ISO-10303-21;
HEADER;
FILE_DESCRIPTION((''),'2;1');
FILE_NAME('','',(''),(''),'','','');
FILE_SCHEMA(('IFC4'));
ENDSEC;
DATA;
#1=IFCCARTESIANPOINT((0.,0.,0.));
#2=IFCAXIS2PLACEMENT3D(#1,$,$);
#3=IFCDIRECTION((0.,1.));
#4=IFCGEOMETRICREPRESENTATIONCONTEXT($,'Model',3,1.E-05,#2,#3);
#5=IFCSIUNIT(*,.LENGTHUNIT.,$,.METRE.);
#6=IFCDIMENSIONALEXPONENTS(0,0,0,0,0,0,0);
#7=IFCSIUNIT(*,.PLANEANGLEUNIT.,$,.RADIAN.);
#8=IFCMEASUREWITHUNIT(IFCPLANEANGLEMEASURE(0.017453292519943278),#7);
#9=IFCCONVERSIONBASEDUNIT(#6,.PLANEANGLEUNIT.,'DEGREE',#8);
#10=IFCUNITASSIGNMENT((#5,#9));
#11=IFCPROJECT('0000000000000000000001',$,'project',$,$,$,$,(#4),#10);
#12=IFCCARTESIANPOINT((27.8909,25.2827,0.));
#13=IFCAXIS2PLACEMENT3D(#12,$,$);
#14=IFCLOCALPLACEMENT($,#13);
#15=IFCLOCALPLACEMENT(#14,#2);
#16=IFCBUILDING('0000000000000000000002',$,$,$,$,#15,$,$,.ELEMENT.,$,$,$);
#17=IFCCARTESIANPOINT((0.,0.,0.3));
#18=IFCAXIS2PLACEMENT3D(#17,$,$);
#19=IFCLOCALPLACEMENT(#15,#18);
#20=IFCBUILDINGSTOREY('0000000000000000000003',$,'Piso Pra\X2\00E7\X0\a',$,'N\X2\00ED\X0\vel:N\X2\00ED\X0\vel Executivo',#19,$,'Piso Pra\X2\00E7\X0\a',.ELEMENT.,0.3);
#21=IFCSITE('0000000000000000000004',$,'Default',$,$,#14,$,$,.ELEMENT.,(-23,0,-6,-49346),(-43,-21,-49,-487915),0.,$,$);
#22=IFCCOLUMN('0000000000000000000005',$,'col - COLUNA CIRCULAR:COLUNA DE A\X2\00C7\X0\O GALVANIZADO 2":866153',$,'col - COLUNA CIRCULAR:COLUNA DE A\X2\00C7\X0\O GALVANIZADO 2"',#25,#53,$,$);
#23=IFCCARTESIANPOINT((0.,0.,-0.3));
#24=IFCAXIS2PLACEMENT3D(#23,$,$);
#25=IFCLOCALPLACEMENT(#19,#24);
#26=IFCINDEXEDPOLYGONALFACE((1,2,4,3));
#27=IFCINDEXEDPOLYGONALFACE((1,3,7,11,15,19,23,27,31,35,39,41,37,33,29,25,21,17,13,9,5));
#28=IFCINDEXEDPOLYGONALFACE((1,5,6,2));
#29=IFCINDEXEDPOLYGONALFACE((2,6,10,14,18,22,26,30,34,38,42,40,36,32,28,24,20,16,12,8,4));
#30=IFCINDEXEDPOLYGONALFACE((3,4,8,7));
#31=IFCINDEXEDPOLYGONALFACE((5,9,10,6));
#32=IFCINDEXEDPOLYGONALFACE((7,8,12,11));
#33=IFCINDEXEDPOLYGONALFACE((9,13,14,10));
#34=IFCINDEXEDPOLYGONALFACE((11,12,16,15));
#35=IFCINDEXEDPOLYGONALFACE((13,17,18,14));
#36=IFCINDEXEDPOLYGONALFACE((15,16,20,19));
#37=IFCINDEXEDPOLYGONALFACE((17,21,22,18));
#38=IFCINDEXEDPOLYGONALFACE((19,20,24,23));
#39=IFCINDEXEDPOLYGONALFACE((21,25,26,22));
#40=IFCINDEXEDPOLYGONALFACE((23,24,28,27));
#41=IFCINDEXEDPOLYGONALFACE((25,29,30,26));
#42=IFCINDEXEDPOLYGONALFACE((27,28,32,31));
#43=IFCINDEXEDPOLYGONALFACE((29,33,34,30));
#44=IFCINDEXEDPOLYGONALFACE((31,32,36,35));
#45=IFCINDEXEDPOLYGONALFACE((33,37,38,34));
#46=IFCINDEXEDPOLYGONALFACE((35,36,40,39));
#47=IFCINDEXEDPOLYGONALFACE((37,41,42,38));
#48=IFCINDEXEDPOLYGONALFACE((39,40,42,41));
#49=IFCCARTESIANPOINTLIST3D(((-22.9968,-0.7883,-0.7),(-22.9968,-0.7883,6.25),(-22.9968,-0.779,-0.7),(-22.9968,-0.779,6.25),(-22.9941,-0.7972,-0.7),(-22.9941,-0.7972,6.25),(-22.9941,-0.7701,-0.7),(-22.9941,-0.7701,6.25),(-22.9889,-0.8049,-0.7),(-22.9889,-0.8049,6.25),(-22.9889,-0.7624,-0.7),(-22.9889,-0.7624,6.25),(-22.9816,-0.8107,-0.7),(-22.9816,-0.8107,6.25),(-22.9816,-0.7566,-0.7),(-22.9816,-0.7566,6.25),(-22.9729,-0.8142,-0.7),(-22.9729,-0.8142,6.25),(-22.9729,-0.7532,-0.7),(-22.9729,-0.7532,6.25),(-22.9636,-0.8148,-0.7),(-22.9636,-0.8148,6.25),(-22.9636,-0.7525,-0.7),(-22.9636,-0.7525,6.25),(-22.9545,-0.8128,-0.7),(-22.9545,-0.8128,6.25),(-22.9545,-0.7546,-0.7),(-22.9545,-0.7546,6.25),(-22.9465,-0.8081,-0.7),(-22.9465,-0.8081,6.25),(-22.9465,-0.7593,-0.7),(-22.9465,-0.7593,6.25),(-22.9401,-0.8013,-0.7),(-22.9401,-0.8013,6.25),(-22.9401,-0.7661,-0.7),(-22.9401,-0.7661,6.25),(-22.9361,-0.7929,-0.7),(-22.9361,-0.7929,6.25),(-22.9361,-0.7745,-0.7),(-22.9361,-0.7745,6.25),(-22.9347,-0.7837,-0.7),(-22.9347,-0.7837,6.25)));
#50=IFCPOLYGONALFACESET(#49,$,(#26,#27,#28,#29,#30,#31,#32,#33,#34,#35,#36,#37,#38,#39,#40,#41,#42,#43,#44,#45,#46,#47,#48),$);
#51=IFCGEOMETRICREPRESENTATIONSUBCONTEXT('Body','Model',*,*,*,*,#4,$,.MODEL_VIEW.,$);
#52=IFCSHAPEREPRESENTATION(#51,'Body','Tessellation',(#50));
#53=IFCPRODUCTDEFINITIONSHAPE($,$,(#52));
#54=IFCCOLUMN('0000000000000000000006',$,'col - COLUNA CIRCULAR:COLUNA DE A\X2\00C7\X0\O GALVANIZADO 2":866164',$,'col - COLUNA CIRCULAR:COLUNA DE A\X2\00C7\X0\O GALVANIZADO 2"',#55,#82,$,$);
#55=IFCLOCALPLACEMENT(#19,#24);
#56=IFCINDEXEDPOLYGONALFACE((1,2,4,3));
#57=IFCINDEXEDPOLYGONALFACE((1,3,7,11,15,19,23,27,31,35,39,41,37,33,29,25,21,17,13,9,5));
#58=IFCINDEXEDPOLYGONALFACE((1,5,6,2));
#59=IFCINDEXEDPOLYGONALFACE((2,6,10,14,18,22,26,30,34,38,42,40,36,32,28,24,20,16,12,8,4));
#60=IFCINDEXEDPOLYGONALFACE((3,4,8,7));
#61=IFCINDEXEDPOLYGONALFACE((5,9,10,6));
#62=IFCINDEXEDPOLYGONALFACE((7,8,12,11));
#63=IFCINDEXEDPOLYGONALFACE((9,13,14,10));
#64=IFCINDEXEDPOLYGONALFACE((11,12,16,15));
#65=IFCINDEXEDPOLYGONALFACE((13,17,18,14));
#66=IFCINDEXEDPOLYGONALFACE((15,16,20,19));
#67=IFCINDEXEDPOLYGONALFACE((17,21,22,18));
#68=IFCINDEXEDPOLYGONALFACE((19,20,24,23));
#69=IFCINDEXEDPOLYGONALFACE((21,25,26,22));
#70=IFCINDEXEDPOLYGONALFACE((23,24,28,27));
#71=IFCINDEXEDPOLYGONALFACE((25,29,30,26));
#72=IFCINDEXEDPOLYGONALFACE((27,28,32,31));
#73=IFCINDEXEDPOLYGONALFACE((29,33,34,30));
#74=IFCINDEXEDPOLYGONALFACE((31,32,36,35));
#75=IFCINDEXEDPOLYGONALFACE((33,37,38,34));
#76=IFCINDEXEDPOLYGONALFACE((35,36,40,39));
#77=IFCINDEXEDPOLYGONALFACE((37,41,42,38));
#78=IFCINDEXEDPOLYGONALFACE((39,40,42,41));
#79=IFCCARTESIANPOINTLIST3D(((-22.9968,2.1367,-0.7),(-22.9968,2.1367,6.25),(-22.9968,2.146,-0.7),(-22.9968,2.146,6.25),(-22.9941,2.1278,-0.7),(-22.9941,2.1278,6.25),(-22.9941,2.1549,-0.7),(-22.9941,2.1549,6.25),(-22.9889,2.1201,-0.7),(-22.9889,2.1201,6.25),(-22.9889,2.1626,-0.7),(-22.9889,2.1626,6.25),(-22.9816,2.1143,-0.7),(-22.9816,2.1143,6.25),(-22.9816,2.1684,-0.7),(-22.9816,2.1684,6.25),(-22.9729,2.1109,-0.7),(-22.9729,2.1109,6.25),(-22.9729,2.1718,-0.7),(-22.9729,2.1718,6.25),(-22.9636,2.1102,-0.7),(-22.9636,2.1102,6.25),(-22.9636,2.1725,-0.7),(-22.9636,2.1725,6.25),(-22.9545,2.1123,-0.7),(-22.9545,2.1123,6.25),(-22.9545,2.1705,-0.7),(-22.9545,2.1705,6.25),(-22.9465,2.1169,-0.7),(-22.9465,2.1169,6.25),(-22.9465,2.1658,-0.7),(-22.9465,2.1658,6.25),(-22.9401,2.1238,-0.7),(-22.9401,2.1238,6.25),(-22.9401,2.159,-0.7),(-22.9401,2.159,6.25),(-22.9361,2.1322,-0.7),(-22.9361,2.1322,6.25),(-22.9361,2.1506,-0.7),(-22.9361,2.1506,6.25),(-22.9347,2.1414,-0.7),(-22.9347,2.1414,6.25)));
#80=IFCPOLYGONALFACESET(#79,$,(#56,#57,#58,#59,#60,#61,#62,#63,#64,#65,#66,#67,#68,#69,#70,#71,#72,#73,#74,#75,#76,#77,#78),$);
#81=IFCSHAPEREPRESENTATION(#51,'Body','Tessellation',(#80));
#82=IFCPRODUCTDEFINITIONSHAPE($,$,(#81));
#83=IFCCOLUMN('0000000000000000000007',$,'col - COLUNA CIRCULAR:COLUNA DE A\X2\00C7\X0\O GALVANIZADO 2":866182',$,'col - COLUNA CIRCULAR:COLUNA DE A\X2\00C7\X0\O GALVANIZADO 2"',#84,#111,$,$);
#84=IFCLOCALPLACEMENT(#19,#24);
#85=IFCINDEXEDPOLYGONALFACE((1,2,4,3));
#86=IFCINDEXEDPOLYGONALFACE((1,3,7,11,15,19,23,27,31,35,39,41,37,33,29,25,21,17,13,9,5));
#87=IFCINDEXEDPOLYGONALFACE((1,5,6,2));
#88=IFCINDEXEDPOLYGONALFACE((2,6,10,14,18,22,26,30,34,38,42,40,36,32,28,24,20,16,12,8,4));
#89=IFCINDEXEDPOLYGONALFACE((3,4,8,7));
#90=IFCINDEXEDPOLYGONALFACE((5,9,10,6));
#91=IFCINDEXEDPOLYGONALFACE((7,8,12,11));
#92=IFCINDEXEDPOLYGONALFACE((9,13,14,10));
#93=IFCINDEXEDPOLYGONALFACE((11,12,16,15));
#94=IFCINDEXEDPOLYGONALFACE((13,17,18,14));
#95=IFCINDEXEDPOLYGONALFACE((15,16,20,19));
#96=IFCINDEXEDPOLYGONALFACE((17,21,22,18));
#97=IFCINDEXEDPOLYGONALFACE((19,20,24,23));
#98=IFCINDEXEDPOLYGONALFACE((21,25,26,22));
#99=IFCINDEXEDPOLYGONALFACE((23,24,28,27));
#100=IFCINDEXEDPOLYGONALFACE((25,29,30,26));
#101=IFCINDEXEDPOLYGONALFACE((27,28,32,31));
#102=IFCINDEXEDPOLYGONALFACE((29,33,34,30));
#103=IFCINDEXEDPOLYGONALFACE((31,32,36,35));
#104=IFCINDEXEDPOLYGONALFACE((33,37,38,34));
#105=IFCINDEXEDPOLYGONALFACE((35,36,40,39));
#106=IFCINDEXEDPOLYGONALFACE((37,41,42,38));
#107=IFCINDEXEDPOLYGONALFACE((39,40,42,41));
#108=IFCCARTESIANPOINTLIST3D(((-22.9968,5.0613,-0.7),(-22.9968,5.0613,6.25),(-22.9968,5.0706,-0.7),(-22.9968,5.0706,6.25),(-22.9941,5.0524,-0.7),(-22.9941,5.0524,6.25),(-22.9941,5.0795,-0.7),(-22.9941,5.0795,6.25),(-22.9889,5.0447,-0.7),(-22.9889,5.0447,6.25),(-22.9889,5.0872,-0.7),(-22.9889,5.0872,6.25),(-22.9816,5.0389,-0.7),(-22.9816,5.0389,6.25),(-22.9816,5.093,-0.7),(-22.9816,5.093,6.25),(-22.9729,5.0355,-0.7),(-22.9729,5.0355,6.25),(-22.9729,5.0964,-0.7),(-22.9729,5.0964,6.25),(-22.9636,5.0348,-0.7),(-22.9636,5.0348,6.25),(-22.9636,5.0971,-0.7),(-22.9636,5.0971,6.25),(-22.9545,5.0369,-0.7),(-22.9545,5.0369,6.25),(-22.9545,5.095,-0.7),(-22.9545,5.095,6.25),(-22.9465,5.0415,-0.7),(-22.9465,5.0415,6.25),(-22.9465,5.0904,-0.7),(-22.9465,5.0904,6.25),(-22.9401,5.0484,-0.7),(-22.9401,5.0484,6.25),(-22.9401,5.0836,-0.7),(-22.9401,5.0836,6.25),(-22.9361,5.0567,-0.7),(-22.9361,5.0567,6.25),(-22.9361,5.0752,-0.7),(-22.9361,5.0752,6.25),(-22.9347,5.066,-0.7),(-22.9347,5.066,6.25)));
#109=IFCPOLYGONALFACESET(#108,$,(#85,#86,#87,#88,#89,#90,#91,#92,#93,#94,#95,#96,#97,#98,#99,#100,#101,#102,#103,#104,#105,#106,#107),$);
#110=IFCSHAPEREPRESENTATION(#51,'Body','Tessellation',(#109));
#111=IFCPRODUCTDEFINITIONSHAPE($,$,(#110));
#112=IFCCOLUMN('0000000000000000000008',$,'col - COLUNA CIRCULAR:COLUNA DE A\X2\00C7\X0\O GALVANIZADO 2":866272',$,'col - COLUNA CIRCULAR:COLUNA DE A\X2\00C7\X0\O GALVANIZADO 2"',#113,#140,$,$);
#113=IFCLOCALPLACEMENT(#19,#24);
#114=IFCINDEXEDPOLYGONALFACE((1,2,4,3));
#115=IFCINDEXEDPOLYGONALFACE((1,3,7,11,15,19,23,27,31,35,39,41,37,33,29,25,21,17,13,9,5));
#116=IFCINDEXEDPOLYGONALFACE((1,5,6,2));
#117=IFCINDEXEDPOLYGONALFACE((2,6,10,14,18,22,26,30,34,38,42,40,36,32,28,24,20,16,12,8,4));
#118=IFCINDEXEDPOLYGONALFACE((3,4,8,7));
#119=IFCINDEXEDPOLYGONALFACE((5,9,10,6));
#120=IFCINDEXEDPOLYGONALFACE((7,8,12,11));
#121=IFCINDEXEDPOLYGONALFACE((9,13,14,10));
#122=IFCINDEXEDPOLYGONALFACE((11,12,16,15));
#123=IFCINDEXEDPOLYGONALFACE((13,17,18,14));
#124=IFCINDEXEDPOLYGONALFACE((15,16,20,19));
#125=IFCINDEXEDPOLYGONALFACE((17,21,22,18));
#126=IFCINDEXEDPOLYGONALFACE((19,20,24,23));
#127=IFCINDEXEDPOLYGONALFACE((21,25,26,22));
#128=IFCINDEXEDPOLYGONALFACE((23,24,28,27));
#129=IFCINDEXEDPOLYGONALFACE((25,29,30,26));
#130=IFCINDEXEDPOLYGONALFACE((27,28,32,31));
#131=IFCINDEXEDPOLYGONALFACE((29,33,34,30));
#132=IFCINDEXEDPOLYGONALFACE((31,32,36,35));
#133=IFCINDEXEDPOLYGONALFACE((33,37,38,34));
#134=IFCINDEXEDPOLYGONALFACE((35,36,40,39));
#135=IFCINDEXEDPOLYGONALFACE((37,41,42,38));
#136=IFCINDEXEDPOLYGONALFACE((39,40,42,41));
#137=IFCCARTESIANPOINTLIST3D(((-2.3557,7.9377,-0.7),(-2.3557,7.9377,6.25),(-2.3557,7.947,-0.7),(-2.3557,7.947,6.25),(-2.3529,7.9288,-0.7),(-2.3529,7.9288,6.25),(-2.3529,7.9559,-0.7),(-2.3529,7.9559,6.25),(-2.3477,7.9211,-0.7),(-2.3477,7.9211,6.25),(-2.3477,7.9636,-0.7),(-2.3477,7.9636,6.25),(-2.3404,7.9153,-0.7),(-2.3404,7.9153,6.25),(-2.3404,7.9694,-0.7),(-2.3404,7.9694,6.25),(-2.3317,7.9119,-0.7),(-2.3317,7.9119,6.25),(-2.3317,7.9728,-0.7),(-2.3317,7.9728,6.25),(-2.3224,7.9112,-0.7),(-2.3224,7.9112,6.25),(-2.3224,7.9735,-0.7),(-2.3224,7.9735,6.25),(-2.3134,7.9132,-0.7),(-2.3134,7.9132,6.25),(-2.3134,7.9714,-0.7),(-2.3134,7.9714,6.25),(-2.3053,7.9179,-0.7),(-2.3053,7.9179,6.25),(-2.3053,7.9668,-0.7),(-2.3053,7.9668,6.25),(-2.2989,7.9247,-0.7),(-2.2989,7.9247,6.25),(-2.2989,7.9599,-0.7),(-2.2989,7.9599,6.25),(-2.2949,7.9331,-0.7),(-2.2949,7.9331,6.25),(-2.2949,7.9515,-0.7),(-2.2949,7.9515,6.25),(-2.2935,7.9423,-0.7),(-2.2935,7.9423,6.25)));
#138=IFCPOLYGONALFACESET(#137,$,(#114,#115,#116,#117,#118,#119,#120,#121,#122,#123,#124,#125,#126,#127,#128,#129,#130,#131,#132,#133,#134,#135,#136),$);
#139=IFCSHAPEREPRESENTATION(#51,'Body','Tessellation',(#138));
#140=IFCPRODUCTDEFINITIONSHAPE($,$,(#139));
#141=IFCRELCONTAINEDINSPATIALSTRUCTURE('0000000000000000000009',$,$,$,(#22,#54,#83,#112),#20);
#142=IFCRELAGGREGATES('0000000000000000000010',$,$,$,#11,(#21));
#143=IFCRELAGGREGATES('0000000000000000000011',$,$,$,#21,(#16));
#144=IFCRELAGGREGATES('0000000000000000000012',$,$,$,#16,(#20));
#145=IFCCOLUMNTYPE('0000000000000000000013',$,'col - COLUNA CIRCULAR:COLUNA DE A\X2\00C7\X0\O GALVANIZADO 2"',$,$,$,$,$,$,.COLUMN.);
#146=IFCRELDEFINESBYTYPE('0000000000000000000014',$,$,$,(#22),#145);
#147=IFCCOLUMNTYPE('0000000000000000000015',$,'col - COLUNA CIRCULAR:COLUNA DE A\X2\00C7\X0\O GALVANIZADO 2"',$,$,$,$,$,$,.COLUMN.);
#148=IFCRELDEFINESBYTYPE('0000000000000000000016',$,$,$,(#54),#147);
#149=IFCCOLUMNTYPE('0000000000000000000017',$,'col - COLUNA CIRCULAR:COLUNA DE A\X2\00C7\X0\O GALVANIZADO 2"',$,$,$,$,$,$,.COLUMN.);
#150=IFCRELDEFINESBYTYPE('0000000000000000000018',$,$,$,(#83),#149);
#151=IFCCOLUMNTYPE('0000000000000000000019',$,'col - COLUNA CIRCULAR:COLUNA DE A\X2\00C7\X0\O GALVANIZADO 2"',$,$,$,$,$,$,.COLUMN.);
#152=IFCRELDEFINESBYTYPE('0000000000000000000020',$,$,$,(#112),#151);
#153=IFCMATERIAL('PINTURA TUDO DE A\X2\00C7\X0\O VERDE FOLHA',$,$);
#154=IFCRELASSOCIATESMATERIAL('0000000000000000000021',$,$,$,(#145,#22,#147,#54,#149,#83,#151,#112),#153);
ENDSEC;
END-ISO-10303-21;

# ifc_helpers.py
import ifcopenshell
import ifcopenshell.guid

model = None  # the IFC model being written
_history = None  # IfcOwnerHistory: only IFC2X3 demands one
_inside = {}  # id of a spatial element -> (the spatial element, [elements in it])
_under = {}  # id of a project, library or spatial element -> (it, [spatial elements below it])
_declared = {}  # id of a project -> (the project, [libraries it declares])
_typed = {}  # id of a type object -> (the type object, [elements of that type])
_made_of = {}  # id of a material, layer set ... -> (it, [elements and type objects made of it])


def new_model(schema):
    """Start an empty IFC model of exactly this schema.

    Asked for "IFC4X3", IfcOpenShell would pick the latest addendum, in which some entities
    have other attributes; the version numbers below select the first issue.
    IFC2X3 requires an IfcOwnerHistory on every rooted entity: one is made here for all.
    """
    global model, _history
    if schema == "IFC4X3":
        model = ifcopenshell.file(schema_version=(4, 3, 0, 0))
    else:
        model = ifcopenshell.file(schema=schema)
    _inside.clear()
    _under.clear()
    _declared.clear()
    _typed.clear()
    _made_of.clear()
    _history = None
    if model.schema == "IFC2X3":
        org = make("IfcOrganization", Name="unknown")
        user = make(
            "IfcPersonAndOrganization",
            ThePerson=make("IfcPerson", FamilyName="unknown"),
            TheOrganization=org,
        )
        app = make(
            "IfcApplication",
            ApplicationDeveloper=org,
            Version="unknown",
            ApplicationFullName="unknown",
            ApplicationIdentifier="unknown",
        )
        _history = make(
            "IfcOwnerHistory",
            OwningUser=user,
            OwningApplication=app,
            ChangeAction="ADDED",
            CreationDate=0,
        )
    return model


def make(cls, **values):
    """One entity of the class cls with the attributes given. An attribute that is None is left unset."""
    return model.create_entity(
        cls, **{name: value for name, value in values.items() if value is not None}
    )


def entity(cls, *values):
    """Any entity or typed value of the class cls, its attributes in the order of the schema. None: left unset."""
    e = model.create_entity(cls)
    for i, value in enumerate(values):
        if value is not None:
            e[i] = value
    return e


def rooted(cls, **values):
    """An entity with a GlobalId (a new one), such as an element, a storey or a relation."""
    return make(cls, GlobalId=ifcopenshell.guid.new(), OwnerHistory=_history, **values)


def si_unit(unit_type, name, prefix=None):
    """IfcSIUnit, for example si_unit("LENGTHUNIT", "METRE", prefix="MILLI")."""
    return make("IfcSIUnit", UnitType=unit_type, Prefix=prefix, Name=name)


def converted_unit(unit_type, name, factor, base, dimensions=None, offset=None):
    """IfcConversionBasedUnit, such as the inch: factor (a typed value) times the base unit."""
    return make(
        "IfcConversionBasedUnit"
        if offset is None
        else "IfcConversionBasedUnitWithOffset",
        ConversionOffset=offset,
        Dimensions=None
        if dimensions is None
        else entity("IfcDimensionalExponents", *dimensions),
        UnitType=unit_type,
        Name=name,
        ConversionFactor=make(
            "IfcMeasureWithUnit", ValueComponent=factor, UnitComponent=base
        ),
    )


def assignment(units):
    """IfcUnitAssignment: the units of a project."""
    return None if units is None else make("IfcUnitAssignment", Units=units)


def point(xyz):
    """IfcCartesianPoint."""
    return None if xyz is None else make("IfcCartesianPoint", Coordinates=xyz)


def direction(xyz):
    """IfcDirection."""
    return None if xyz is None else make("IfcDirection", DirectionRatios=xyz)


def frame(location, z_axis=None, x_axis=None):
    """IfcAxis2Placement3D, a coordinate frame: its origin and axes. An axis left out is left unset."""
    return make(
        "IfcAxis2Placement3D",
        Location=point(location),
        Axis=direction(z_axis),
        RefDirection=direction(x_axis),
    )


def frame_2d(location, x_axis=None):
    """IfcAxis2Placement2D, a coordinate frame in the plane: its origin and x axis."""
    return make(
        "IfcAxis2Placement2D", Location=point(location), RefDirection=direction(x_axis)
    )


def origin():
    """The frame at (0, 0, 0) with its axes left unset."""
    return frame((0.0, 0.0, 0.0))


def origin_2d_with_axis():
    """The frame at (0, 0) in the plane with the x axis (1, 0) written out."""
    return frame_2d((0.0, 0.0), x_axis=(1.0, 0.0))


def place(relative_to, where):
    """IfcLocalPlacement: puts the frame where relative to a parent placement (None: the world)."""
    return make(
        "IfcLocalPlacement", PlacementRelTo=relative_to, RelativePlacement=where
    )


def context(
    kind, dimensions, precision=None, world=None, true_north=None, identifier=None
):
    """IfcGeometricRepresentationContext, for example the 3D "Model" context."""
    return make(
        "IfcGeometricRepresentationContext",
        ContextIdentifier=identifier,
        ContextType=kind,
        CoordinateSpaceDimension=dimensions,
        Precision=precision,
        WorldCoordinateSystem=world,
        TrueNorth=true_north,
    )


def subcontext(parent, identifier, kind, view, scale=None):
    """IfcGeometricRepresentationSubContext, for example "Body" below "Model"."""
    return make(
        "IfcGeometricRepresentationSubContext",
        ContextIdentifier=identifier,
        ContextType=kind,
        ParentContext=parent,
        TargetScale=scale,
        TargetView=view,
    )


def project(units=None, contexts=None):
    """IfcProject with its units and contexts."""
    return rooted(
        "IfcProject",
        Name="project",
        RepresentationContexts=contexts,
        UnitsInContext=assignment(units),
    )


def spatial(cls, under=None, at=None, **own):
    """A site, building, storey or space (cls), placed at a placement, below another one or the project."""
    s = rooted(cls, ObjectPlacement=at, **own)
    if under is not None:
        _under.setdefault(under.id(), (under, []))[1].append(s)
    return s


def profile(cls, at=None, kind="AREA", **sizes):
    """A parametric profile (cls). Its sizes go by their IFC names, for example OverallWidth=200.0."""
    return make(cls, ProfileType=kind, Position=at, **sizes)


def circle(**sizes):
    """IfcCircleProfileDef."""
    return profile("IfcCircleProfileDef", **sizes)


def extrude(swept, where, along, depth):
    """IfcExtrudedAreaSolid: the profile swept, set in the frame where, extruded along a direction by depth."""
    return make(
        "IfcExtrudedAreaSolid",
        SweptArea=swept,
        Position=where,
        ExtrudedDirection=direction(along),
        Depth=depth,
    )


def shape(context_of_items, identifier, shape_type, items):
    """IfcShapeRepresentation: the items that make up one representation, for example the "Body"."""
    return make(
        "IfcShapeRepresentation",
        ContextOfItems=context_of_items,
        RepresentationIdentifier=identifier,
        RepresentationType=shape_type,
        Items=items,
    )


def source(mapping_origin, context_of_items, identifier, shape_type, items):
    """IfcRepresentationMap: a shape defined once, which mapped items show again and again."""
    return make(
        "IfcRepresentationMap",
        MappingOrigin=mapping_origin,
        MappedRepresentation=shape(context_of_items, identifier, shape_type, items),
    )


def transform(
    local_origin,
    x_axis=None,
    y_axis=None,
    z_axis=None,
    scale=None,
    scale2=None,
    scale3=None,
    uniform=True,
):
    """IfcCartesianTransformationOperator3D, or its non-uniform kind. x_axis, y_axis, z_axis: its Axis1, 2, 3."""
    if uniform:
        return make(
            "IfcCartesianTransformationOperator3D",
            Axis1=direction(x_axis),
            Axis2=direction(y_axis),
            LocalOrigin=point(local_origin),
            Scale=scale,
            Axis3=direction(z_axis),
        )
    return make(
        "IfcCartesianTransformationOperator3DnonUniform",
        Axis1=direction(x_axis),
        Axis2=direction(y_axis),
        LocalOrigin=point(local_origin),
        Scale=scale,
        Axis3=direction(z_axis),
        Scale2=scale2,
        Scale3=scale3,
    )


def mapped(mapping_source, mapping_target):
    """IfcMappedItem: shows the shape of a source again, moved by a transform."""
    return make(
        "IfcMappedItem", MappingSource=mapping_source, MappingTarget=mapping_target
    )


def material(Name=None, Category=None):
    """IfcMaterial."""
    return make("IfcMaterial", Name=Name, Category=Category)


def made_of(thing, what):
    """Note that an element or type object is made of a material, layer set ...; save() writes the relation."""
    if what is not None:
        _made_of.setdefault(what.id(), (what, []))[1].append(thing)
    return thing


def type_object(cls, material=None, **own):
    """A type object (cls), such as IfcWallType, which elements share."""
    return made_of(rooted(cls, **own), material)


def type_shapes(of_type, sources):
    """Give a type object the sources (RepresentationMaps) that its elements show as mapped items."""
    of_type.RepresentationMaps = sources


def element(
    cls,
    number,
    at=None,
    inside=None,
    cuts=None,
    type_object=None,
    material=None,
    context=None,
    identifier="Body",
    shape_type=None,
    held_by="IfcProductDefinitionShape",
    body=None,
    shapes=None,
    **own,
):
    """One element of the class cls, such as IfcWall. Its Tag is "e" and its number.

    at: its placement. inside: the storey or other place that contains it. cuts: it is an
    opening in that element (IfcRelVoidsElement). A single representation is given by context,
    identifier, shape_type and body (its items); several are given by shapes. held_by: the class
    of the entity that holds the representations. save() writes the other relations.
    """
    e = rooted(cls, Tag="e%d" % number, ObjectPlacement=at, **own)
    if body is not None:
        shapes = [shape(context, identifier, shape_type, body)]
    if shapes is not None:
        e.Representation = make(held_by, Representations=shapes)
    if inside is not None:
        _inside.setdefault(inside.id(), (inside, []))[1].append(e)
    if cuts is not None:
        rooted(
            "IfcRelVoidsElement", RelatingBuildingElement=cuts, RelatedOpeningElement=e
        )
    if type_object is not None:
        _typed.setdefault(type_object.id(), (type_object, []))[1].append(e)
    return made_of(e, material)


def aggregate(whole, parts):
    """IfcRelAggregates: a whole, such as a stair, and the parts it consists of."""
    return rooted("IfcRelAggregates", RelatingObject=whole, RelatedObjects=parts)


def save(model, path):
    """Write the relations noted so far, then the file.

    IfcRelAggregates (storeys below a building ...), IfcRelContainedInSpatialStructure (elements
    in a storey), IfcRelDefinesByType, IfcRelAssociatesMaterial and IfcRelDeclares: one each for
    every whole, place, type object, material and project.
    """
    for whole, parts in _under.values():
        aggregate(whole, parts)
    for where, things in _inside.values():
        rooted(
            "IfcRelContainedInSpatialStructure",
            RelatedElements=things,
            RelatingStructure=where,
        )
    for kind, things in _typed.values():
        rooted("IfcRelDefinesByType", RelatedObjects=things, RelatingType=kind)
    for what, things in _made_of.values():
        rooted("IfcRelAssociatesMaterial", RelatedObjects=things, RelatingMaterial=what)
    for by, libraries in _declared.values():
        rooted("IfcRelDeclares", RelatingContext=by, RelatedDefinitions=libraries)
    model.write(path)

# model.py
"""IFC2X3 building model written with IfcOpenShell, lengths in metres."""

from ifc_helpers import new_model, entity, si_unit, converted_unit, direction, frame, origin, origin_2d_with_axis, place, context, subcontext, project, spatial, circle, extrude, source, transform, mapped, material, type_object, type_shapes, element, save


model = new_model("IFC2X3")

# Units and contexts
model_context = context("Model", 3, precision=1e-05, world=origin(), true_north=direction((0.0, 1.0)))
body_context = subcontext(model_context, "Body", "Model", "MODEL_VIEW")
ifc_project = project(units=[si_unit("LENGTHUNIT", "METRE"), converted_unit("PLANEANGLEUNIT", "DEGREE", entity("IfcPlaneAngleMeasure", 0.017453292519943278), si_unit("PLANEANGLEUNIT", "RADIAN"), dimensions=[0, 0, 0, 0, 0, 0, 0])], contexts=[model_context])

# Site, building, storey
site_placement = place(None, frame((27.8909, 25.2827, 0.0)))
site = spatial("IfcSite", under=ifc_project, at=site_placement, Name="Default", CompositionType="ELEMENT", RefLatitude=(-23, 0, -6, -49346), RefLongitude=(-43, -21, -49, -487915), RefElevation=0.0)
building_placement = place(site_placement, origin())
building = spatial("IfcBuilding", under=site, at=building_placement, CompositionType="ELEMENT")
storey_placement = place(building_placement, frame((0.0, 0.0, 0.3)))
storey = spatial("IfcBuildingStorey", under=building, at=storey_placement, Name="Piso Praça", ObjectType="Nível:Nível Executivo", LongName="Piso Praça", CompositionType="ELEMENT", Elevation=0.3)

# Columns
ifc_material_1 = material(Name="PINTURA TUDO DE AÇO VERDE FOLHA")
column_type_1 = type_object("IfcColumnType", Name="col - COLUNA CIRCULAR:COLUNA DE AÇO GALVANIZADO 2\"", PredefinedType="COLUMN", material=ifc_material_1)
shared_shape_1 = source(origin(), body_context, "Body", "SweptSolid", [
    extrude(circle(Radius=0.0312, at=origin_2d_with_axis()), frame((-22.9659, -0.7837, -0.7)), (0.0, 0.0, 1.0), 6.95),
])
type_shapes(column_type_1, [shared_shape_1])
column_1_placement = place(storey_placement, frame((0.0, 0.0, -0.3)))
element("IfcColumn", 1, at=column_1_placement, inside=storey, type_object=column_type_1, material=ifc_material_1, Name="col - COLUNA CIRCULAR:COLUNA DE AÇO GALVANIZADO 2\":866153", ObjectType="col - COLUNA CIRCULAR:COLUNA DE AÇO GALVANIZADO 2\"", context=body_context, shape_type="MappedRepresentation", body=[
    mapped(shared_shape_1, transform((0.0, 0.0, 0.0), scale=1.0)),
])
column_type_2 = type_object("IfcColumnType", Name="col - COLUNA CIRCULAR:COLUNA DE AÇO GALVANIZADO 2\"", PredefinedType="COLUMN", material=ifc_material_1)
shared_shape_2 = source(origin(), body_context, "Body", "SweptSolid", [
    extrude(circle(Radius=0.0312, at=origin_2d_with_axis()), frame((-22.9659, 2.1414, -0.7)), (0.0, 0.0, 1.0), 6.95),
])
type_shapes(column_type_2, [shared_shape_2])
column_2_placement = place(storey_placement, frame((0.0, 0.0, -0.3)))
element("IfcColumn", 2, at=column_2_placement, inside=storey, type_object=column_type_2, material=ifc_material_1, Name="col - COLUNA CIRCULAR:COLUNA DE AÇO GALVANIZADO 2\":866164", ObjectType="col - COLUNA CIRCULAR:COLUNA DE AÇO GALVANIZADO 2\"", context=body_context, shape_type="MappedRepresentation", body=[
    mapped(shared_shape_2, transform((0.0, 0.0, 0.0), scale=1.0)),
])
column_type_3 = type_object("IfcColumnType", Name="col - COLUNA CIRCULAR:COLUNA DE AÇO GALVANIZADO 2\"", PredefinedType="COLUMN", material=ifc_material_1)
shared_shape_3 = source(origin(), body_context, "Body", "SweptSolid", [
    extrude(circle(Radius=0.0312, at=origin_2d_with_axis()), frame((-22.9659, 5.066, -0.7)), (0.0, 0.0, 1.0), 6.95),
])
type_shapes(column_type_3, [shared_shape_3])
column_3_placement = place(storey_placement, frame((0.0, 0.0, -0.3)))
element("IfcColumn", 3, at=column_3_placement, inside=storey, type_object=column_type_3, material=ifc_material_1, Name="col - COLUNA CIRCULAR:COLUNA DE AÇO GALVANIZADO 2\":866182", ObjectType="col - COLUNA CIRCULAR:COLUNA DE AÇO GALVANIZADO 2\"", context=body_context, shape_type="MappedRepresentation", body=[
    mapped(shared_shape_3, transform((0.0, 0.0, 0.0), scale=1.0)),
])
column_type_4 = type_object("IfcColumnType", Name="col - COLUNA CIRCULAR:COLUNA DE AÇO GALVANIZADO 2\"", PredefinedType="COLUMN", material=ifc_material_1)
shared_shape_4 = source(origin(), body_context, "Body", "SweptSolid", [
    extrude(circle(Radius=0.0312, at=origin_2d_with_axis()), frame((-2.3248, 7.9423, -0.7)), (0.0, 0.0, 1.0), 6.95),
])
type_shapes(column_type_4, [shared_shape_4])
column_4_placement = place(storey_placement, frame((0.0, 0.0, -0.3)))
element("IfcColumn", 4, at=column_4_placement, inside=storey, type_object=column_type_4, material=ifc_material_1, Name="col - COLUNA CIRCULAR:COLUNA DE AÇO GALVANIZADO 2\":866272", ObjectType="col - COLUNA CIRCULAR:COLUNA DE AÇO GALVANIZADO 2\"", context=body_context, shape_type="MappedRepresentation", body=[
    mapped(shared_shape_4, transform((0.0, 0.0, 0.0), scale=1.0)),
])

save(model, "model.ifc")
